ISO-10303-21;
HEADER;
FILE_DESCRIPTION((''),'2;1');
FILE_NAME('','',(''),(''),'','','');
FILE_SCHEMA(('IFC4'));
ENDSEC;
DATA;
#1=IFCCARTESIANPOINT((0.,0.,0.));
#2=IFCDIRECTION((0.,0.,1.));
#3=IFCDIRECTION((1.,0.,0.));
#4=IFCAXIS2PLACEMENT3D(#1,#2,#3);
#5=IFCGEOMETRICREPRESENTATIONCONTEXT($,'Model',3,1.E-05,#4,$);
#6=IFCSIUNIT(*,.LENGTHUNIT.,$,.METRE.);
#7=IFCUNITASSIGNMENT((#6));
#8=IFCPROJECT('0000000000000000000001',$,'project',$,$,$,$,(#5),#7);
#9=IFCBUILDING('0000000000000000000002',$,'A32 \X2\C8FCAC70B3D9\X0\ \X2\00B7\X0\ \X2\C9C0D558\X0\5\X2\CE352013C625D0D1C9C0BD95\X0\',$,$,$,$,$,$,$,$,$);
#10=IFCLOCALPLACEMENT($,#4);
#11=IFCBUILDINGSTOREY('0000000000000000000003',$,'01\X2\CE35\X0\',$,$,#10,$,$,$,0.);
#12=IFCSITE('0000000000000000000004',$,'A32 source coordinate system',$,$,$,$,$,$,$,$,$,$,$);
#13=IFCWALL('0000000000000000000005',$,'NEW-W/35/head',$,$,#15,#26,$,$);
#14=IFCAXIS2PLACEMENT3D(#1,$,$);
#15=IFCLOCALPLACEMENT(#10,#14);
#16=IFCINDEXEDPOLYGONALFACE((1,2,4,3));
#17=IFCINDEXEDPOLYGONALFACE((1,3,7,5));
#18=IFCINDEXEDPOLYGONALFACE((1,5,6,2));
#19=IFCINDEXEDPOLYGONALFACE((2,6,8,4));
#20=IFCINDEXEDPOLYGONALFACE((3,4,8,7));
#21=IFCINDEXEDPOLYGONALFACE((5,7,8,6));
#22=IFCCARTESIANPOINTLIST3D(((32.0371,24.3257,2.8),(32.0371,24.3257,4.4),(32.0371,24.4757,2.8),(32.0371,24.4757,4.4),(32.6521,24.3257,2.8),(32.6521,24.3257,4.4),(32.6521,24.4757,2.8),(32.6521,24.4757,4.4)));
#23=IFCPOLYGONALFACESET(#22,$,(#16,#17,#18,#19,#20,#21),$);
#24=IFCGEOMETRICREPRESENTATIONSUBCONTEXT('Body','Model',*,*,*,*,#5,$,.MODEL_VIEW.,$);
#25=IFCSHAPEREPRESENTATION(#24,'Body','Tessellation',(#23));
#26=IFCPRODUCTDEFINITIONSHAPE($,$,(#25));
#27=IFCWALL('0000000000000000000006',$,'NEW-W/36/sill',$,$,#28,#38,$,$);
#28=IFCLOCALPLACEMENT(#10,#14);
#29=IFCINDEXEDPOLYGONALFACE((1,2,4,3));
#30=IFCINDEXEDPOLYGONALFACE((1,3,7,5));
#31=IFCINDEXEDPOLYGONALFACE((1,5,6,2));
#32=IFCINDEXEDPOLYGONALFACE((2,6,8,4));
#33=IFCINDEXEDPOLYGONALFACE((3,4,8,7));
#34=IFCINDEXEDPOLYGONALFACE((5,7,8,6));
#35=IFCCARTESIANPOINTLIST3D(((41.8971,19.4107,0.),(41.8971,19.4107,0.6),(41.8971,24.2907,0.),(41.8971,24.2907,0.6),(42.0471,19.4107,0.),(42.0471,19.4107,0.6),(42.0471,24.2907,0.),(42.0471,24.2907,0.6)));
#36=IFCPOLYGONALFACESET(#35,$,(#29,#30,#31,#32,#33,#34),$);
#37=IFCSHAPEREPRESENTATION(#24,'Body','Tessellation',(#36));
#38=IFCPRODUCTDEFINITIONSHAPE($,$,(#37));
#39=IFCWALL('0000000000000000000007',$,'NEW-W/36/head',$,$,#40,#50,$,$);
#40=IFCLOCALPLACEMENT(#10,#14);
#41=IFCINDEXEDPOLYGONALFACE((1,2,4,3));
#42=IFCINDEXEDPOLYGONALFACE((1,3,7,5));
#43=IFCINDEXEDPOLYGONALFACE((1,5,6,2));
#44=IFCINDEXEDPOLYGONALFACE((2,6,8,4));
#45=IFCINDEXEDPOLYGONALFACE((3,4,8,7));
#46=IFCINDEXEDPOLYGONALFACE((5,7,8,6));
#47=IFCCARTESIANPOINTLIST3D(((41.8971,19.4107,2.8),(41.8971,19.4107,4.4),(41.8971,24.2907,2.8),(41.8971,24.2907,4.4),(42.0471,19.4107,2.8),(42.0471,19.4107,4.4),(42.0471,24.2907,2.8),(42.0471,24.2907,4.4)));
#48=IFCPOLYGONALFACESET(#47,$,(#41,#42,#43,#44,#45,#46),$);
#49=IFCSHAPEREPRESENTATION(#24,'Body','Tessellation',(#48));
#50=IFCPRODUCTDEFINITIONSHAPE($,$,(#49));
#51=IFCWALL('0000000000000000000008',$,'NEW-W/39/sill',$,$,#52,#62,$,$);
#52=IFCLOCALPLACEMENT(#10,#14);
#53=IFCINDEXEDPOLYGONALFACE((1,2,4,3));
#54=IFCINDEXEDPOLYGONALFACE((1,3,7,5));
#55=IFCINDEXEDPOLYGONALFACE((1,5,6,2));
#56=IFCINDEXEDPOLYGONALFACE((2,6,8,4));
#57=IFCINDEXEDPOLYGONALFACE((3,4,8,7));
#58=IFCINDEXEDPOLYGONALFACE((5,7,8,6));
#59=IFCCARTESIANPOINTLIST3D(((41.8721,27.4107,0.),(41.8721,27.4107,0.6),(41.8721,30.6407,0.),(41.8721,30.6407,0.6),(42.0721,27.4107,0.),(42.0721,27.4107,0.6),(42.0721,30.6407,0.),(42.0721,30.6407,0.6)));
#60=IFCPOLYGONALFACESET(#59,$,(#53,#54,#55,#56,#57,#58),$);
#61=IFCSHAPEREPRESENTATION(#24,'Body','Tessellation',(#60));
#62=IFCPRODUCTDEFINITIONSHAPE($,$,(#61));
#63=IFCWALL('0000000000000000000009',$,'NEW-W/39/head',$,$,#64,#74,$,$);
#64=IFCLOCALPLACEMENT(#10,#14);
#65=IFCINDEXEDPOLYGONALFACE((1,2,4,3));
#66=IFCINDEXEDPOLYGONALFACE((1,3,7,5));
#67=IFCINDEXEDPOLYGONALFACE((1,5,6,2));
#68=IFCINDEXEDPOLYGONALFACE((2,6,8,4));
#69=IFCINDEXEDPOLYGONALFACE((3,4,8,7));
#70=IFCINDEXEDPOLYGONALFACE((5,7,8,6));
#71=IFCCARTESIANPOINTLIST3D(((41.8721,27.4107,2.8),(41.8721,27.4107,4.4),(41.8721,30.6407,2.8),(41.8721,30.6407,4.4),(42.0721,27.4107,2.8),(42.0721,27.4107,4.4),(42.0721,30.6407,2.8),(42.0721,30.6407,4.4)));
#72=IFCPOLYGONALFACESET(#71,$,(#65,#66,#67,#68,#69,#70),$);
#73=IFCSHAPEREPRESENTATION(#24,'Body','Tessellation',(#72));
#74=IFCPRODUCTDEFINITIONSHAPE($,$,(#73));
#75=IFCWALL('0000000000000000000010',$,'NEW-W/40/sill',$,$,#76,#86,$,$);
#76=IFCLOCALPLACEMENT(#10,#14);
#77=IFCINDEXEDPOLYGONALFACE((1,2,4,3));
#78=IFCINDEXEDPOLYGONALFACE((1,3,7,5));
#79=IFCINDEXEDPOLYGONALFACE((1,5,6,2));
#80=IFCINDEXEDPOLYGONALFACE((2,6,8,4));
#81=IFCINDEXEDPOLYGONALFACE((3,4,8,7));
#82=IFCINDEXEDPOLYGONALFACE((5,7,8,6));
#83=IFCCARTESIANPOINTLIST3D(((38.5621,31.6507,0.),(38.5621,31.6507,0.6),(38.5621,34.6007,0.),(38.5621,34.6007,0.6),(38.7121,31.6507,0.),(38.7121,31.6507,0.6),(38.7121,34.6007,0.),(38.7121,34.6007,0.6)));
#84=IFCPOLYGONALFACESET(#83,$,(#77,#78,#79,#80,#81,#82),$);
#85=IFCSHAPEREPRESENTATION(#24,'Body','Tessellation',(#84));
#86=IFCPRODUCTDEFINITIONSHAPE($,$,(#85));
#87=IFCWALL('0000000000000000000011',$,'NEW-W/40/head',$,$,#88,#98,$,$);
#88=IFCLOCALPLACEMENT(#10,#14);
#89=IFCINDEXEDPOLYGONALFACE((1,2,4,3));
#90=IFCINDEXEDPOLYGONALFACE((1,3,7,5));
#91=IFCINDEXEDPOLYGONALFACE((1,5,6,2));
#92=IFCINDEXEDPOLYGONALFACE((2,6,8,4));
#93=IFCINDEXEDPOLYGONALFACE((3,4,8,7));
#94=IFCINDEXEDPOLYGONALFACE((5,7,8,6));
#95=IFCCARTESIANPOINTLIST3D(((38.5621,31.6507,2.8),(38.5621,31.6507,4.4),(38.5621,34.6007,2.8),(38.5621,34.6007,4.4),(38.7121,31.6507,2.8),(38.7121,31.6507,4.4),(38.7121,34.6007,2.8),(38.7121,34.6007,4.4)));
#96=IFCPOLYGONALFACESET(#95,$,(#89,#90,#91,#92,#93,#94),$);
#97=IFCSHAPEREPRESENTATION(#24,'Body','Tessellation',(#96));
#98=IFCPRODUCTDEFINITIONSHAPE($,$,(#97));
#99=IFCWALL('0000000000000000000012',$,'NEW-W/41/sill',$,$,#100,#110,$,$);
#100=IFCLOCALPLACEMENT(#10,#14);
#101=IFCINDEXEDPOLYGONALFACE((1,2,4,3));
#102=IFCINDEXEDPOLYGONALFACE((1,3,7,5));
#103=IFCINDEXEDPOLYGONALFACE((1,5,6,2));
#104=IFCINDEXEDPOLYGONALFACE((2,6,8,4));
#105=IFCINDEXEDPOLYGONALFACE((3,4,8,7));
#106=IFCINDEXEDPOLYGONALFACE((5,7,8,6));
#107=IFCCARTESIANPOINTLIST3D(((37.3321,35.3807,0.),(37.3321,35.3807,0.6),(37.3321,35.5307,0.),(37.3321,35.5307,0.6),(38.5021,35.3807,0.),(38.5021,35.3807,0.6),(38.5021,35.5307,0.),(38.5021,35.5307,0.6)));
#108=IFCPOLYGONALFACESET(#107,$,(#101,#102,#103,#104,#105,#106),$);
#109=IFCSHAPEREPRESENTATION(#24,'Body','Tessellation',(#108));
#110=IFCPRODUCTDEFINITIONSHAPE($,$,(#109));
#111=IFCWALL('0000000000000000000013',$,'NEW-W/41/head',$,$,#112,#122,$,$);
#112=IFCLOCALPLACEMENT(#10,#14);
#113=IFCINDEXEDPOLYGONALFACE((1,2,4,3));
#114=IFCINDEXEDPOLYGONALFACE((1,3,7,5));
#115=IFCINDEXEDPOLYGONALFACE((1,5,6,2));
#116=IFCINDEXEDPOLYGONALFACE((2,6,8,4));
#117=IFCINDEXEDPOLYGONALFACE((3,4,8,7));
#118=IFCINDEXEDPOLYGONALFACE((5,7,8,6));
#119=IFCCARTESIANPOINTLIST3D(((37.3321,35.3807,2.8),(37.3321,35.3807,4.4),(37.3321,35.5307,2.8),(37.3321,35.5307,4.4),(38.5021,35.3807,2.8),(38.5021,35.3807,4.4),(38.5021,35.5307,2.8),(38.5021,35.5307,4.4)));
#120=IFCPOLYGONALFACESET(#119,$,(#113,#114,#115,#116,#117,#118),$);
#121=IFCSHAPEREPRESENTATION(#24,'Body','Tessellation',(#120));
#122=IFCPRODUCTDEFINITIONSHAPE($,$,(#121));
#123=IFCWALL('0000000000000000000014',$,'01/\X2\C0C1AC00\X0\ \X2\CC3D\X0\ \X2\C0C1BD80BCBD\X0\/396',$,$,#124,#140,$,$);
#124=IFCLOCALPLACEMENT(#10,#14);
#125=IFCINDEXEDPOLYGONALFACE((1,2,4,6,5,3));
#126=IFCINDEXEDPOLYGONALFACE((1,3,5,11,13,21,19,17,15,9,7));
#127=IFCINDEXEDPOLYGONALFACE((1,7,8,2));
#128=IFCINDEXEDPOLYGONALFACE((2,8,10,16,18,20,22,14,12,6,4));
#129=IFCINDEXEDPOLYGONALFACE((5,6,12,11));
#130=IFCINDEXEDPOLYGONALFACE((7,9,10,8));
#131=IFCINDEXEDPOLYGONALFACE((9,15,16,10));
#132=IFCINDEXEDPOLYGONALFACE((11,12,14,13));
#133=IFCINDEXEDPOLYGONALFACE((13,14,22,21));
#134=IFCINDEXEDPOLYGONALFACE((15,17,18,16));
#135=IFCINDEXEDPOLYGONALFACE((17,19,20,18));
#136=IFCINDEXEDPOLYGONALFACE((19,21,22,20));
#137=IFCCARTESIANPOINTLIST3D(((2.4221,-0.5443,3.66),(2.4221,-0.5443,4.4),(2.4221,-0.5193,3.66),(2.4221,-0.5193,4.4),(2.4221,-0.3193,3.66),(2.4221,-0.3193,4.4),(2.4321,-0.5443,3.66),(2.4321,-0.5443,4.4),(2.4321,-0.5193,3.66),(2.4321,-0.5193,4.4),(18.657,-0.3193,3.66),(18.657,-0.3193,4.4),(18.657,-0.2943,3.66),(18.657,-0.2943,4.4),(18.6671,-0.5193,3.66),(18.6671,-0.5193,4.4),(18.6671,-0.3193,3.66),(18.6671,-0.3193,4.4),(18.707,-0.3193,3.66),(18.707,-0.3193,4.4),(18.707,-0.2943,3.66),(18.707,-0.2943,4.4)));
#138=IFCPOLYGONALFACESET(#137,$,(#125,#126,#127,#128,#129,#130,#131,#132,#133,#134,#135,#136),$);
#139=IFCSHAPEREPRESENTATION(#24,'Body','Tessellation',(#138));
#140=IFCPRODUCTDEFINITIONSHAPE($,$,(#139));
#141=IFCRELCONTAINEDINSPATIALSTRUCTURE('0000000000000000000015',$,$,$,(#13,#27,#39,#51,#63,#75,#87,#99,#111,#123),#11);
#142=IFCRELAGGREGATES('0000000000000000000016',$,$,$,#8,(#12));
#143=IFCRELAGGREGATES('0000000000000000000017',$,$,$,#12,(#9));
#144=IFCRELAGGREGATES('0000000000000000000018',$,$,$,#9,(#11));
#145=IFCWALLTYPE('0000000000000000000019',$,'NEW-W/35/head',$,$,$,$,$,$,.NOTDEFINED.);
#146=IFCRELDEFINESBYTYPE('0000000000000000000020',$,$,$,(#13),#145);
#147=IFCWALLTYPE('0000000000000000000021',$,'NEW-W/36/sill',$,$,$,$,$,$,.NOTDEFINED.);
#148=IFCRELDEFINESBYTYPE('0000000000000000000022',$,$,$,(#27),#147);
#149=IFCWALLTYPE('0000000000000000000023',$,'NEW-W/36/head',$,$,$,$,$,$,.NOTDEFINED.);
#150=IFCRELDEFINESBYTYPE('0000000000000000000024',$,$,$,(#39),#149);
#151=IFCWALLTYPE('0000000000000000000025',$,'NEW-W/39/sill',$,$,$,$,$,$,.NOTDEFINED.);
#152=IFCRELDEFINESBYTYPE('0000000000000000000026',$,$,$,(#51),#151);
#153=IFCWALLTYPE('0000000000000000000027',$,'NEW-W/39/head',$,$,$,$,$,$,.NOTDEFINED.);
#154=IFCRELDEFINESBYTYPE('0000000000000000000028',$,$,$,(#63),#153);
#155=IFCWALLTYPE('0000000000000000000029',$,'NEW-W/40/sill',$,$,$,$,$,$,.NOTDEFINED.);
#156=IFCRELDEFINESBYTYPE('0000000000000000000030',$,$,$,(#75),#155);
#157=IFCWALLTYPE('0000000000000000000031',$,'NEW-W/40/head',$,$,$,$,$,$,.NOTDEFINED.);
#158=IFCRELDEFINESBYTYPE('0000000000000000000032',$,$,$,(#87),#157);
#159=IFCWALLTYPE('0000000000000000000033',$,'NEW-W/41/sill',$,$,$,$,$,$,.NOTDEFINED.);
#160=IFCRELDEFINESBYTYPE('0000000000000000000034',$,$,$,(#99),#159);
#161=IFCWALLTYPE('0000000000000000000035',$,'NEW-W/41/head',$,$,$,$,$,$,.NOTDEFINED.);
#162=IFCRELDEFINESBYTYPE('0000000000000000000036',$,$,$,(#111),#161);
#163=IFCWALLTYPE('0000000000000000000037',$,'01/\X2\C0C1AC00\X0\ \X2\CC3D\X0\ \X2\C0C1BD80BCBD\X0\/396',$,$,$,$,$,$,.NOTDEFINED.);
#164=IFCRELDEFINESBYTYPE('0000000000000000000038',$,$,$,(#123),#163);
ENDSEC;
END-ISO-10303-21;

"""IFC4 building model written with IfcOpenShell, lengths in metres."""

from ifc_helpers import new_model, si_unit, frame, origin, origin_with_axes, place, context, subcontext, project, spatial, polyline, outline, extrude, source, transform, mapped, type_object, type_shapes, element, save


model = new_model("IFC4")

# Units and contexts
model_context = context("Model", 3, precision=1e-05, world=origin_with_axes())
body_context = subcontext(model_context, "Body", "Model", "MODEL_VIEW")
ifc_project = project(units=[si_unit("LENGTHUNIT", "METRE")], contexts=[model_context])

# Site, building, storey
site = spatial("IfcSite", under=ifc_project, Name="A32 source coordinate system")
building = spatial("IfcBuilding", under=site, Name="A32 주거동 · 지하5층–옥탑지붕")
storey_placement = place(None, origin_with_axes())
storey = spatial("IfcBuildingStorey", under=building, at=storey_placement, Name="01층", Elevation=0.0)

# Walls
wall_type_1 = type_object("IfcWallType", Name="NEW-W/35/head", PredefinedType="NOTDEFINED")
shared_shape_1 = source(origin(), body_context, "Body", "SweptSolid", [
    extrude(outline(polyline([(32.0371, 24.3257), (32.0371, 24.4757), (32.6521, 24.4757), (32.6521, 24.3257), (32.0371, 24.3257)])), frame((0.0, 0.0, 2.8)), (0.0, 0.0, 1.0), 1.6),
])
type_shapes(wall_type_1, [shared_shape_1])
wall_1_placement = place(storey_placement, origin_with_axes())
element("IfcWall", 1, at=wall_1_placement, inside=storey, type_object=wall_type_1, Name="NEW-W/35/head", context=body_context, shape_type="MappedRepresentation", body=[
    mapped(shared_shape_1, transform((0.0, 0.0, 0.0), scale=1.0)),
])
wall_type_2 = type_object("IfcWallType", Name="NEW-W/36/sill", PredefinedType="NOTDEFINED")
shared_shape_2 = source(origin(), body_context, "Body", "SweptSolid", [
    extrude(outline(polyline([(41.8971, 19.4107), (41.8971, 24.2907), (42.0471, 24.2907), (42.0471, 19.4107), (41.8971, 19.4107)])), origin(), (0.0, 0.0, 1.0), 0.6),
])
type_shapes(wall_type_2, [shared_shape_2])
wall_2_placement = place(storey_placement, origin_with_axes())
element("IfcWall", 2, at=wall_2_placement, inside=storey, type_object=wall_type_2, Name="NEW-W/36/sill", context=body_context, shape_type="MappedRepresentation", body=[
    mapped(shared_shape_2, transform((0.0, 0.0, 0.0), scale=1.0)),
])
wall_type_3 = type_object("IfcWallType", Name="NEW-W/36/head", PredefinedType="NOTDEFINED")
shared_shape_3 = source(origin(), body_context, "Body", "SweptSolid", [
    extrude(outline(polyline([(41.8971, 19.4107), (41.8971, 24.2907), (42.0471, 24.2907), (42.0471, 19.4107), (41.8971, 19.4107)])), frame((0.0, 0.0, 2.8)), (0.0, 0.0, 1.0), 1.6),
])
type_shapes(wall_type_3, [shared_shape_3])
wall_3_placement = place(storey_placement, origin_with_axes())
element("IfcWall", 3, at=wall_3_placement, inside=storey, type_object=wall_type_3, Name="NEW-W/36/head", context=body_context, shape_type="MappedRepresentation", body=[
    mapped(shared_shape_3, transform((0.0, 0.0, 0.0), scale=1.0)),
])
wall_type_4 = type_object("IfcWallType", Name="NEW-W/39/sill", PredefinedType="NOTDEFINED")
shared_shape_4 = source(origin(), body_context, "Body", "SweptSolid", [
    extrude(outline(polyline([(41.8721, 27.4107), (41.8721, 30.6407), (42.0721, 30.6407), (42.0721, 27.4107), (41.8721, 27.4107)])), origin(), (0.0, 0.0, 1.0), 0.6),
])
type_shapes(wall_type_4, [shared_shape_4])
wall_4_placement = place(storey_placement, origin_with_axes())
element("IfcWall", 4, at=wall_4_placement, inside=storey, type_object=wall_type_4, Name="NEW-W/39/sill", context=body_context, shape_type="MappedRepresentation", body=[
    mapped(shared_shape_4, transform((0.0, 0.0, 0.0), scale=1.0)),
])
wall_type_5 = type_object("IfcWallType", Name="NEW-W/39/head", PredefinedType="NOTDEFINED")
shared_shape_5 = source(origin(), body_context, "Body", "SweptSolid", [
    extrude(outline(polyline([(41.8721, 27.4107), (41.8721, 30.6407), (42.0721, 30.6407), (42.0721, 27.4107), (41.8721, 27.4107)])), frame((0.0, 0.0, 2.8)), (0.0, 0.0, 1.0), 1.6),
])
type_shapes(wall_type_5, [shared_shape_5])
wall_5_placement = place(storey_placement, origin_with_axes())
element("IfcWall", 5, at=wall_5_placement, inside=storey, type_object=wall_type_5, Name="NEW-W/39/head", context=body_context, shape_type="MappedRepresentation", body=[
    mapped(shared_shape_5, transform((0.0, 0.0, 0.0), scale=1.0)),
])
wall_type_6 = type_object("IfcWallType", Name="NEW-W/40/sill", PredefinedType="NOTDEFINED")
shared_shape_6 = source(origin(), body_context, "Body", "SweptSolid", [
    extrude(outline(polyline([(38.7121, 31.6507), (38.5621, 31.6507), (38.5621, 34.6007), (38.7121, 34.6007), (38.7121, 31.6507)])), origin(), (0.0, 0.0, 1.0), 0.6),
])
type_shapes(wall_type_6, [shared_shape_6])
wall_6_placement = place(storey_placement, origin_with_axes())
element("IfcWall", 6, at=wall_6_placement, inside=storey, type_object=wall_type_6, Name="NEW-W/40/sill", context=body_context, shape_type="MappedRepresentation", body=[
    mapped(shared_shape_6, transform((0.0, 0.0, 0.0), scale=1.0)),
])
wall_type_7 = type_object("IfcWallType", Name="NEW-W/40/head", PredefinedType="NOTDEFINED")
shared_shape_7 = source(origin(), body_context, "Body", "SweptSolid", [
    extrude(outline(polyline([(38.7121, 31.6507), (38.5621, 31.6507), (38.5621, 34.6007), (38.7121, 34.6007), (38.7121, 31.6507)])), frame((0.0, 0.0, 2.8)), (0.0, 0.0, 1.0), 1.6),
])
type_shapes(wall_type_7, [shared_shape_7])
wall_7_placement = place(storey_placement, origin_with_axes())
element("IfcWall", 7, at=wall_7_placement, inside=storey, type_object=wall_type_7, Name="NEW-W/40/head", context=body_context, shape_type="MappedRepresentation", body=[
    mapped(shared_shape_7, transform((0.0, 0.0, 0.0), scale=1.0)),
])
wall_type_8 = type_object("IfcWallType", Name="NEW-W/41/sill", PredefinedType="NOTDEFINED")
shared_shape_8 = source(origin(), body_context, "Body", "SweptSolid", [
    extrude(outline(polyline([(37.3321, 35.3807), (37.3321, 35.5307), (38.5021, 35.5307), (38.5021, 35.3807), (37.3321, 35.3807)])), origin(), (0.0, 0.0, 1.0), 0.6),
])
type_shapes(wall_type_8, [shared_shape_8])
wall_8_placement = place(storey_placement, origin_with_axes())
element("IfcWall", 8, at=wall_8_placement, inside=storey, type_object=wall_type_8, Name="NEW-W/41/sill", context=body_context, shape_type="MappedRepresentation", body=[
    mapped(shared_shape_8, transform((0.0, 0.0, 0.0), scale=1.0)),
])
wall_type_9 = type_object("IfcWallType", Name="NEW-W/41/head", PredefinedType="NOTDEFINED")
shared_shape_9 = source(origin(), body_context, "Body", "SweptSolid", [
    extrude(outline(polyline([(37.3321, 35.3807), (37.3321, 35.5307), (38.5021, 35.5307), (38.5021, 35.3807), (37.3321, 35.3807)])), frame((0.0, 0.0, 2.8)), (0.0, 0.0, 1.0), 1.6),
])
type_shapes(wall_type_9, [shared_shape_9])
wall_9_placement = place(storey_placement, origin_with_axes())
element("IfcWall", 9, at=wall_9_placement, inside=storey, type_object=wall_type_9, Name="NEW-W/41/head", context=body_context, shape_type="MappedRepresentation", body=[
    mapped(shared_shape_9, transform((0.0, 0.0, 0.0), scale=1.0)),
])
wall_type_10 = type_object("IfcWallType", Name="01/상가 창 상부벽/396", PredefinedType="NOTDEFINED")
shared_shape_10 = source(origin(), body_context, "Body", "SweptSolid", [
    extrude(outline(polyline([(2.4071, -0.3193), (18.657, -0.3193), (18.657, -0.2943), (18.707, -0.2943), (18.707, -0.3193), (18.6671, -0.3193), (18.6671, -0.5193), (2.4321, -0.5193), (2.4321, -0.5443), (2.4221, -0.5443), (2.4221, -0.5193), (2.4221, -0.3193), (2.4071, -0.3193), (2.4071, -0.3193)])), frame((0.0, 0.0, 3.66)), (0.0, 0.0, 1.0), 0.74),
])
type_shapes(wall_type_10, [shared_shape_10])
wall_10_placement = place(storey_placement, origin_with_axes())
element("IfcWall", 10, at=wall_10_placement, inside=storey, type_object=wall_type_10, Name="01/상가 창 상부벽/396", context=body_context, shape_type="MappedRepresentation", body=[
    mapped(shared_shape_10, transform((0.0, 0.0, 0.0), scale=1.0)),
])

save(model, "model.ifc")
